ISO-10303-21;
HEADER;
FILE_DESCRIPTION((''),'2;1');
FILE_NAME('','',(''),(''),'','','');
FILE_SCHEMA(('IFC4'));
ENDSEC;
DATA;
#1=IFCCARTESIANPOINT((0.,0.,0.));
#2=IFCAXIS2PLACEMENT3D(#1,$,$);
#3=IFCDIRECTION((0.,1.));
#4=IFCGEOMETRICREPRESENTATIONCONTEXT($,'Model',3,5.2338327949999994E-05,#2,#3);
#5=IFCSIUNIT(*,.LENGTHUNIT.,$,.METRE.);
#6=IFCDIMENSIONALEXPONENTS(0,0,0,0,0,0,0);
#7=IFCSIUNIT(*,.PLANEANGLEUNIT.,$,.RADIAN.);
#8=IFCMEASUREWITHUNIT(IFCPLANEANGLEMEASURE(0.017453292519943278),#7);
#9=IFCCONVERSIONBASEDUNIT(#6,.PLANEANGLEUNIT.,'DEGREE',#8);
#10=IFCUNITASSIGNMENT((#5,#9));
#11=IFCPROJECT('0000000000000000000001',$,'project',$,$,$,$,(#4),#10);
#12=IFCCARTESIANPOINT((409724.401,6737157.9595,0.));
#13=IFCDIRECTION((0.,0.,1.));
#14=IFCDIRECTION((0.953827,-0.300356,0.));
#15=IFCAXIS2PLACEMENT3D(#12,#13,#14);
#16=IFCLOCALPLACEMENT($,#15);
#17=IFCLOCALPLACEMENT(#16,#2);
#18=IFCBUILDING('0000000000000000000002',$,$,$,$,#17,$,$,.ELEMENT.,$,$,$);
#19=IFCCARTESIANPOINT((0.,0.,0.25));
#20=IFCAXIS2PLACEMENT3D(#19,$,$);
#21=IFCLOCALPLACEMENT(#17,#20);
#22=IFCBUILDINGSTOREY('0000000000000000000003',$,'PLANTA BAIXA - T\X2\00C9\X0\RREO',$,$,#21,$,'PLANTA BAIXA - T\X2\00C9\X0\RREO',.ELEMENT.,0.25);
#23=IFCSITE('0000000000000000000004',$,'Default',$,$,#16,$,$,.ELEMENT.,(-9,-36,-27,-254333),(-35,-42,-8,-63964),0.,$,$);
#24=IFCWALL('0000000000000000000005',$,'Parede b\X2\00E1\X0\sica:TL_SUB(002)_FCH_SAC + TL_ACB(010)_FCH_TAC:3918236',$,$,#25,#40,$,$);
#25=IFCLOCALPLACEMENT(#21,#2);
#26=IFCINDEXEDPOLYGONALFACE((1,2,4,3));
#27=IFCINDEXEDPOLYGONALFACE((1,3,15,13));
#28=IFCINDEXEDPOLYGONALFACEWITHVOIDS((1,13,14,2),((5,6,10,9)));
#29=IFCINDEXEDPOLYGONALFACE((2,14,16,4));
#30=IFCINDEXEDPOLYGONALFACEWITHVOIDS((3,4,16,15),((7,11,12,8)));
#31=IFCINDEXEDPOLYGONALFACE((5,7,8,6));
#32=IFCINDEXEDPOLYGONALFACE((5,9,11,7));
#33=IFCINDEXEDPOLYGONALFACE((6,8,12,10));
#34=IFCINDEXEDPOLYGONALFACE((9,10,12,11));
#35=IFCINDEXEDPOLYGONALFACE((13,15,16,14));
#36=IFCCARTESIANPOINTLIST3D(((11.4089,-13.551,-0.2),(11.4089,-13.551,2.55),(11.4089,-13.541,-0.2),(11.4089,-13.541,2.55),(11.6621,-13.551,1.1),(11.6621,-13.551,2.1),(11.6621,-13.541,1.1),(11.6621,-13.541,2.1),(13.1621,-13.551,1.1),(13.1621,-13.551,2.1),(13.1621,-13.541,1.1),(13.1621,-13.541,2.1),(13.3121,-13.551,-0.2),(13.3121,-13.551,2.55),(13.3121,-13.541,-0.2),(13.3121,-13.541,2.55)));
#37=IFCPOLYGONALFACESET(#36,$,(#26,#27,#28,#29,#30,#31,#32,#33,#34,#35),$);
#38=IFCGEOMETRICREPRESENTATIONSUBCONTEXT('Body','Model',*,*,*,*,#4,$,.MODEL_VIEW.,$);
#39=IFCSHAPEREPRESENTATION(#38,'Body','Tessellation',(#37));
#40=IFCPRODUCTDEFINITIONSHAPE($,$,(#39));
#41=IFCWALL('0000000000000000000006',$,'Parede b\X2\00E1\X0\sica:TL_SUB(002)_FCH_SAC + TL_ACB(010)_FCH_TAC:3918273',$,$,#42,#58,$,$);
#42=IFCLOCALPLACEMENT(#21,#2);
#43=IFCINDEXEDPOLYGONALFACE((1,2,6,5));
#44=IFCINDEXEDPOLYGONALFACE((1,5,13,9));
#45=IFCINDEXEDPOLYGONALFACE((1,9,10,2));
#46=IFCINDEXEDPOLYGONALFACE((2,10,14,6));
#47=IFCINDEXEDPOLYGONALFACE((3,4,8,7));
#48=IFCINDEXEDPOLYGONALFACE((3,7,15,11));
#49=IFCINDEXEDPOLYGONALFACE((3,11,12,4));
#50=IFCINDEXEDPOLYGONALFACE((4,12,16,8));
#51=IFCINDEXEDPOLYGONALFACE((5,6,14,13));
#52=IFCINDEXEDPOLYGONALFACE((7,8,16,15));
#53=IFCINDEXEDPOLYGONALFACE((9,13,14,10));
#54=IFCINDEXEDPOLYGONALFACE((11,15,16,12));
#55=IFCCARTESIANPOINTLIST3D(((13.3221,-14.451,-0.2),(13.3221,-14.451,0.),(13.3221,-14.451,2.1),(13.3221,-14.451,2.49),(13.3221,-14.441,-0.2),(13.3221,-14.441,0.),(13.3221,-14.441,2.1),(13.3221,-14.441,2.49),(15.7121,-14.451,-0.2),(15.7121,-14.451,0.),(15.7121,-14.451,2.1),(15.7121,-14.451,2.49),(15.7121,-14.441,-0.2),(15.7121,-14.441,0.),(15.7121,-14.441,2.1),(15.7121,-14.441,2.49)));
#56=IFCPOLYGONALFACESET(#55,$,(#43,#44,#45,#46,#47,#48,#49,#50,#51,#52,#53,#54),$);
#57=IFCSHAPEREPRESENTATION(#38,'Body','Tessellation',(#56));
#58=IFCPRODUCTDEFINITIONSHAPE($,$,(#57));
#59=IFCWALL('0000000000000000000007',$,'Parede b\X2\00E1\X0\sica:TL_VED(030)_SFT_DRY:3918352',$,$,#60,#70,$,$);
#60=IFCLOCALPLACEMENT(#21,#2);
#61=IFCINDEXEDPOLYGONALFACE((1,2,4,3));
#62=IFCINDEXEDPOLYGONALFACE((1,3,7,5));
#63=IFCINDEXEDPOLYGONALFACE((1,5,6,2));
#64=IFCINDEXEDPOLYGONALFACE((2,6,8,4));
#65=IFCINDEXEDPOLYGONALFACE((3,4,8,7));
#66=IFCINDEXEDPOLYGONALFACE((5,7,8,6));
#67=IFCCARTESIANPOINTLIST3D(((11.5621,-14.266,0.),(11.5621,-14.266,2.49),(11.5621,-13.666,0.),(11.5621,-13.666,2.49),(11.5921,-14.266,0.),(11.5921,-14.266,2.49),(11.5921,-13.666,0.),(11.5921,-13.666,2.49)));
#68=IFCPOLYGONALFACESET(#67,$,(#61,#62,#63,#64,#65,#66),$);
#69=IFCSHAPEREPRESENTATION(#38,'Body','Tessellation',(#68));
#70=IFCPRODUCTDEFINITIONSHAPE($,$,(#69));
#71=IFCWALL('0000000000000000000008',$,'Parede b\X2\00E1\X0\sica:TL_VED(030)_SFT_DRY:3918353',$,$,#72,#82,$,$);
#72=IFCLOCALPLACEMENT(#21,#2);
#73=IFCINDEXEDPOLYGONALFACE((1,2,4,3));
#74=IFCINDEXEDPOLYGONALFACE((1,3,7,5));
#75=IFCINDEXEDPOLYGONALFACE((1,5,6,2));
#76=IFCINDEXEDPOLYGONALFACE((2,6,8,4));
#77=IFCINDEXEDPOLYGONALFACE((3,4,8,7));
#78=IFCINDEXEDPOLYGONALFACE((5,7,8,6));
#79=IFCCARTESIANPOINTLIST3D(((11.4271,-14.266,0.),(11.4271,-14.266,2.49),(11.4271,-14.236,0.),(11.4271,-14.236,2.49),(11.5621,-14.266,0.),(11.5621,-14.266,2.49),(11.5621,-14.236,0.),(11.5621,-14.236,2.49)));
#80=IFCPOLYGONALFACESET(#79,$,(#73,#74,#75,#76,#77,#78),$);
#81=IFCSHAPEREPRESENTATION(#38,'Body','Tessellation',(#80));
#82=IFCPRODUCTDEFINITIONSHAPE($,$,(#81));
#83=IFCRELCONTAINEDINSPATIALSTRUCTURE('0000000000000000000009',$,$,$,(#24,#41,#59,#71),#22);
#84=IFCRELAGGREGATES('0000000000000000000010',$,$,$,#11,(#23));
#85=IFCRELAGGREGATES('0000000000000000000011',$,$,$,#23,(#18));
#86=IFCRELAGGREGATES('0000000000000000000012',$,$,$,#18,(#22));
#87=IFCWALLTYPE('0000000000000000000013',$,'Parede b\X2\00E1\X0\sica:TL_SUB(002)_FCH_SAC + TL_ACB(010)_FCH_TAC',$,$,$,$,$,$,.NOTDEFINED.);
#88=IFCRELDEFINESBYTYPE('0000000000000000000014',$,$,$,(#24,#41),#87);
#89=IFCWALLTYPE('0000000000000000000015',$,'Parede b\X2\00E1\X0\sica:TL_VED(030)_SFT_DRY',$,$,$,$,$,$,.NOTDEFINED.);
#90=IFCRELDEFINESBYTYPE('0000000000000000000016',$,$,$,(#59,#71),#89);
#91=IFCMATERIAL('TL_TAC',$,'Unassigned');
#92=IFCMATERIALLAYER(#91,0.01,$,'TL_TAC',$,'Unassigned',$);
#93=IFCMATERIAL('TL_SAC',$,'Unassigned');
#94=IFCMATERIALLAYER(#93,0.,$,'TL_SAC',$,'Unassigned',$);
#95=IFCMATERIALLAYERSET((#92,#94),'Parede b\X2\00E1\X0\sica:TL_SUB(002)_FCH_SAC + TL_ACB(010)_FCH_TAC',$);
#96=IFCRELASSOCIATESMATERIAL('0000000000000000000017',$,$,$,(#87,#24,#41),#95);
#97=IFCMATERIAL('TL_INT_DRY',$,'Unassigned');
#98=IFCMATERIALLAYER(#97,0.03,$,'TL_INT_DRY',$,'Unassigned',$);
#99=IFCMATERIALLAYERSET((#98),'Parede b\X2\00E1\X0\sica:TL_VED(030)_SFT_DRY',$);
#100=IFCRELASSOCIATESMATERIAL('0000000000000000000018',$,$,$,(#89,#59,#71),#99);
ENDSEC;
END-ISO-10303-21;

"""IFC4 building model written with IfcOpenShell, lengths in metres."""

from ifc_helpers import new_model, entity, si_unit, converted_unit, direction, frame, frame_2d, origin, place, context, subcontext, project, spatial, rectangle, extrude, material, layer, layer_set, layer_usage, type_object, element, save


model = new_model("IFC4")

# Units and contexts
model_context = context("Model", 3, precision=5.2338327949999994e-05, world=origin(), true_north=direction((0.0, 1.0)))
body_context = subcontext(model_context, "Body", "Model", "MODEL_VIEW")
ifc_project = project(units=[si_unit("LENGTHUNIT", "METRE"), converted_unit("PLANEANGLEUNIT", "DEGREE", entity("IfcPlaneAngleMeasure", 0.017453292519943278), si_unit("PLANEANGLEUNIT", "RADIAN"), dimensions=[0, 0, 0, 0, 0, 0, 0])], contexts=[model_context])

# Site, building, storey
site_placement = place(None, frame((409724.401, 6737157.9595, 0.0), z_axis=(0.0, 0.0, 1.0), x_axis=(0.953827, -0.300356, 0.0)))
site = spatial("IfcSite", under=ifc_project, at=site_placement, Name="Default", CompositionType="ELEMENT", RefLatitude=(-9, -36, -27, -254333), RefLongitude=(-35, -42, -8, -63964), RefElevation=0.0)
building_placement = place(site_placement, origin())
building = spatial("IfcBuilding", under=site, at=building_placement, CompositionType="ELEMENT")
storey_placement = place(building_placement, frame((0.0, 0.0, 0.25)))
storey = spatial("IfcBuildingStorey", under=building, at=storey_placement, Name="PLANTA BAIXA - TÉRREO", LongName="PLANTA BAIXA - TÉRREO", CompositionType="ELEMENT", Elevation=0.25)

# Shared definitions
ifc_material_1 = material(Name="TL_SAC", Category="Unassigned")

# Walls, openings
ifc_material_2 = material(Name="TL_TAC", Category="Unassigned")
ifc_layer_1 = layer(ifc_material_2, 0.01, Name="TL_TAC", Category="Unassigned")
ifc_layer_2 = layer(ifc_material_1, 0.0, Name="TL_SAC", Category="Unassigned")
ifc_layer_set_1 = layer_set([ifc_layer_1, ifc_layer_2], Name="Parede básica:TL_SUB(002)_FCH_SAC + TL_ACB(010)_FCH_TAC")
ifc_layer_usage_1 = layer_usage(ifc_layer_set_1, "AXIS2", "POSITIVE", -0.005)
wall_type_1 = type_object("IfcWallType", Name="Parede básica:TL_SUB(002)_FCH_SAC + TL_ACB(010)_FCH_TAC", PredefinedType="NOTDEFINED", material=ifc_layer_set_1)
wall_1_placement = place(storey_placement, frame((11.4089, -13.546, -0.2)))
wall_1 = element("IfcWall", 1, at=wall_1_placement, inside=storey, type_object=wall_type_1, material=ifc_layer_usage_1, Name="Parede básica:TL_SUB(002)_FCH_SAC + TL_ACB(010)_FCH_TAC:3918236", context=body_context, shape_type="SweptSolid", body=[
    extrude(rectangle(XDim=1.9032, YDim=0.01, at=frame_2d((0.9516, 0.0), x_axis=(-1.0, 0.0))), origin(), (0.0, 0.0, 1.0), 2.75),
])
opening_1_placement = place(wall_1_placement, frame((-11.4089, 13.546, 1.3)))
element("IfcOpeningElement", 2, at=opening_1_placement, cuts=wall_1, PredefinedType="OPENING", context=body_context, shape_type="SweptSolid", body=[
    extrude(rectangle(XDim=1.0, YDim=1.5, at=frame_2d((0.0, 0.0), x_axis=(0.0, 1.0))), frame((12.4121, -15.175, 0.5), z_axis=(0.0, 1.0, 0.0), x_axis=(1.0, 0.0, 0.0)), (0.0, 0.0, 1.0), 3.048),
])
ifc_layer_usage_2 = layer_usage(ifc_layer_set_1, "AXIS2", "NEGATIVE", 0.005)
wall_2_placement = place(storey_placement, frame((13.3221, -14.446, -0.2)))
wall_2 = element("IfcWall", 3, at=wall_2_placement, inside=storey, type_object=wall_type_1, material=ifc_layer_usage_2, Name="Parede básica:TL_SUB(002)_FCH_SAC + TL_ACB(010)_FCH_TAC:3918273", context=body_context, shape_type="SweptSolid", body=[
    extrude(rectangle(XDim=2.39, YDim=0.01, at=frame_2d((1.195, 0.0), x_axis=(-1.0, 0.0))), origin(), (0.0, 0.0, 1.0), 2.69),
])
opening_2_placement = place(wall_2_placement, frame((-13.3221, 14.446, 0.2)))
element("IfcOpeningElement", 4, at=opening_2_placement, cuts=wall_2, PredefinedType="OPENING", context=body_context, shape_type="SweptSolid", body=[
    extrude(rectangle(XDim=2.1, YDim=2.4, at=frame_2d((0.0, 0.0), x_axis=(0.0, 1.0))), frame((14.5121, -15.975, 1.05), z_axis=(0.0, 1.0, 0.0), x_axis=(-1.0, 0.0, 0.0)), (0.0, 0.0, 1.0), 3.048),
])

# Walls
ifc_material_3 = material(Name="TL_INT_DRY", Category="Unassigned")
ifc_layer_3 = layer(ifc_material_3, 0.03, Name="TL_INT_DRY", Category="Unassigned")
ifc_layer_set_2 = layer_set([ifc_layer_3], Name="Parede básica:TL_VED(030)_SFT_DRY")
ifc_layer_usage_3 = layer_usage(ifc_layer_set_2, "AXIS2", "NEGATIVE", 0.015)
wall_type_2 = type_object("IfcWallType", Name="Parede básica:TL_VED(030)_SFT_DRY", PredefinedType="NOTDEFINED", material=ifc_layer_set_2)
wall_3_placement = place(storey_placement, frame((11.5771, -13.666, 0.0), z_axis=(0.0, 0.0, 1.0), x_axis=(0.0, -1.0, 0.0)))
element("IfcWall", 5, at=wall_3_placement, inside=storey, type_object=wall_type_2, material=ifc_layer_usage_3, Name="Parede básica:TL_VED(030)_SFT_DRY:3918352", context=body_context, shape_type="SweptSolid", body=[
    extrude(rectangle(XDim=0.6, YDim=0.03, at=frame_2d((0.3, 0.0), x_axis=(-1.0, 0.0))), origin(), (0.0, 0.0, 1.0), 2.49),
])
ifc_layer_usage_4 = layer_usage(ifc_layer_set_2, "AXIS2", "NEGATIVE", 0.015)
wall_4_placement = place(storey_placement, frame((11.5621, -14.251, 0.0), z_axis=(0.0, 0.0, 1.0), x_axis=(-1.0, 0.0, 0.0)))
element("IfcWall", 6, at=wall_4_placement, inside=storey, type_object=wall_type_2, material=ifc_layer_usage_4, Name="Parede básica:TL_VED(030)_SFT_DRY:3918353", context=body_context, shape_type="SweptSolid", body=[
    extrude(rectangle(XDim=0.135, YDim=0.03, at=frame_2d((0.0675, 0.0), x_axis=(-1.0, 0.0))), origin(), (0.0, 0.0, 1.0), 2.49),
])

save(model, "model.ifc")
